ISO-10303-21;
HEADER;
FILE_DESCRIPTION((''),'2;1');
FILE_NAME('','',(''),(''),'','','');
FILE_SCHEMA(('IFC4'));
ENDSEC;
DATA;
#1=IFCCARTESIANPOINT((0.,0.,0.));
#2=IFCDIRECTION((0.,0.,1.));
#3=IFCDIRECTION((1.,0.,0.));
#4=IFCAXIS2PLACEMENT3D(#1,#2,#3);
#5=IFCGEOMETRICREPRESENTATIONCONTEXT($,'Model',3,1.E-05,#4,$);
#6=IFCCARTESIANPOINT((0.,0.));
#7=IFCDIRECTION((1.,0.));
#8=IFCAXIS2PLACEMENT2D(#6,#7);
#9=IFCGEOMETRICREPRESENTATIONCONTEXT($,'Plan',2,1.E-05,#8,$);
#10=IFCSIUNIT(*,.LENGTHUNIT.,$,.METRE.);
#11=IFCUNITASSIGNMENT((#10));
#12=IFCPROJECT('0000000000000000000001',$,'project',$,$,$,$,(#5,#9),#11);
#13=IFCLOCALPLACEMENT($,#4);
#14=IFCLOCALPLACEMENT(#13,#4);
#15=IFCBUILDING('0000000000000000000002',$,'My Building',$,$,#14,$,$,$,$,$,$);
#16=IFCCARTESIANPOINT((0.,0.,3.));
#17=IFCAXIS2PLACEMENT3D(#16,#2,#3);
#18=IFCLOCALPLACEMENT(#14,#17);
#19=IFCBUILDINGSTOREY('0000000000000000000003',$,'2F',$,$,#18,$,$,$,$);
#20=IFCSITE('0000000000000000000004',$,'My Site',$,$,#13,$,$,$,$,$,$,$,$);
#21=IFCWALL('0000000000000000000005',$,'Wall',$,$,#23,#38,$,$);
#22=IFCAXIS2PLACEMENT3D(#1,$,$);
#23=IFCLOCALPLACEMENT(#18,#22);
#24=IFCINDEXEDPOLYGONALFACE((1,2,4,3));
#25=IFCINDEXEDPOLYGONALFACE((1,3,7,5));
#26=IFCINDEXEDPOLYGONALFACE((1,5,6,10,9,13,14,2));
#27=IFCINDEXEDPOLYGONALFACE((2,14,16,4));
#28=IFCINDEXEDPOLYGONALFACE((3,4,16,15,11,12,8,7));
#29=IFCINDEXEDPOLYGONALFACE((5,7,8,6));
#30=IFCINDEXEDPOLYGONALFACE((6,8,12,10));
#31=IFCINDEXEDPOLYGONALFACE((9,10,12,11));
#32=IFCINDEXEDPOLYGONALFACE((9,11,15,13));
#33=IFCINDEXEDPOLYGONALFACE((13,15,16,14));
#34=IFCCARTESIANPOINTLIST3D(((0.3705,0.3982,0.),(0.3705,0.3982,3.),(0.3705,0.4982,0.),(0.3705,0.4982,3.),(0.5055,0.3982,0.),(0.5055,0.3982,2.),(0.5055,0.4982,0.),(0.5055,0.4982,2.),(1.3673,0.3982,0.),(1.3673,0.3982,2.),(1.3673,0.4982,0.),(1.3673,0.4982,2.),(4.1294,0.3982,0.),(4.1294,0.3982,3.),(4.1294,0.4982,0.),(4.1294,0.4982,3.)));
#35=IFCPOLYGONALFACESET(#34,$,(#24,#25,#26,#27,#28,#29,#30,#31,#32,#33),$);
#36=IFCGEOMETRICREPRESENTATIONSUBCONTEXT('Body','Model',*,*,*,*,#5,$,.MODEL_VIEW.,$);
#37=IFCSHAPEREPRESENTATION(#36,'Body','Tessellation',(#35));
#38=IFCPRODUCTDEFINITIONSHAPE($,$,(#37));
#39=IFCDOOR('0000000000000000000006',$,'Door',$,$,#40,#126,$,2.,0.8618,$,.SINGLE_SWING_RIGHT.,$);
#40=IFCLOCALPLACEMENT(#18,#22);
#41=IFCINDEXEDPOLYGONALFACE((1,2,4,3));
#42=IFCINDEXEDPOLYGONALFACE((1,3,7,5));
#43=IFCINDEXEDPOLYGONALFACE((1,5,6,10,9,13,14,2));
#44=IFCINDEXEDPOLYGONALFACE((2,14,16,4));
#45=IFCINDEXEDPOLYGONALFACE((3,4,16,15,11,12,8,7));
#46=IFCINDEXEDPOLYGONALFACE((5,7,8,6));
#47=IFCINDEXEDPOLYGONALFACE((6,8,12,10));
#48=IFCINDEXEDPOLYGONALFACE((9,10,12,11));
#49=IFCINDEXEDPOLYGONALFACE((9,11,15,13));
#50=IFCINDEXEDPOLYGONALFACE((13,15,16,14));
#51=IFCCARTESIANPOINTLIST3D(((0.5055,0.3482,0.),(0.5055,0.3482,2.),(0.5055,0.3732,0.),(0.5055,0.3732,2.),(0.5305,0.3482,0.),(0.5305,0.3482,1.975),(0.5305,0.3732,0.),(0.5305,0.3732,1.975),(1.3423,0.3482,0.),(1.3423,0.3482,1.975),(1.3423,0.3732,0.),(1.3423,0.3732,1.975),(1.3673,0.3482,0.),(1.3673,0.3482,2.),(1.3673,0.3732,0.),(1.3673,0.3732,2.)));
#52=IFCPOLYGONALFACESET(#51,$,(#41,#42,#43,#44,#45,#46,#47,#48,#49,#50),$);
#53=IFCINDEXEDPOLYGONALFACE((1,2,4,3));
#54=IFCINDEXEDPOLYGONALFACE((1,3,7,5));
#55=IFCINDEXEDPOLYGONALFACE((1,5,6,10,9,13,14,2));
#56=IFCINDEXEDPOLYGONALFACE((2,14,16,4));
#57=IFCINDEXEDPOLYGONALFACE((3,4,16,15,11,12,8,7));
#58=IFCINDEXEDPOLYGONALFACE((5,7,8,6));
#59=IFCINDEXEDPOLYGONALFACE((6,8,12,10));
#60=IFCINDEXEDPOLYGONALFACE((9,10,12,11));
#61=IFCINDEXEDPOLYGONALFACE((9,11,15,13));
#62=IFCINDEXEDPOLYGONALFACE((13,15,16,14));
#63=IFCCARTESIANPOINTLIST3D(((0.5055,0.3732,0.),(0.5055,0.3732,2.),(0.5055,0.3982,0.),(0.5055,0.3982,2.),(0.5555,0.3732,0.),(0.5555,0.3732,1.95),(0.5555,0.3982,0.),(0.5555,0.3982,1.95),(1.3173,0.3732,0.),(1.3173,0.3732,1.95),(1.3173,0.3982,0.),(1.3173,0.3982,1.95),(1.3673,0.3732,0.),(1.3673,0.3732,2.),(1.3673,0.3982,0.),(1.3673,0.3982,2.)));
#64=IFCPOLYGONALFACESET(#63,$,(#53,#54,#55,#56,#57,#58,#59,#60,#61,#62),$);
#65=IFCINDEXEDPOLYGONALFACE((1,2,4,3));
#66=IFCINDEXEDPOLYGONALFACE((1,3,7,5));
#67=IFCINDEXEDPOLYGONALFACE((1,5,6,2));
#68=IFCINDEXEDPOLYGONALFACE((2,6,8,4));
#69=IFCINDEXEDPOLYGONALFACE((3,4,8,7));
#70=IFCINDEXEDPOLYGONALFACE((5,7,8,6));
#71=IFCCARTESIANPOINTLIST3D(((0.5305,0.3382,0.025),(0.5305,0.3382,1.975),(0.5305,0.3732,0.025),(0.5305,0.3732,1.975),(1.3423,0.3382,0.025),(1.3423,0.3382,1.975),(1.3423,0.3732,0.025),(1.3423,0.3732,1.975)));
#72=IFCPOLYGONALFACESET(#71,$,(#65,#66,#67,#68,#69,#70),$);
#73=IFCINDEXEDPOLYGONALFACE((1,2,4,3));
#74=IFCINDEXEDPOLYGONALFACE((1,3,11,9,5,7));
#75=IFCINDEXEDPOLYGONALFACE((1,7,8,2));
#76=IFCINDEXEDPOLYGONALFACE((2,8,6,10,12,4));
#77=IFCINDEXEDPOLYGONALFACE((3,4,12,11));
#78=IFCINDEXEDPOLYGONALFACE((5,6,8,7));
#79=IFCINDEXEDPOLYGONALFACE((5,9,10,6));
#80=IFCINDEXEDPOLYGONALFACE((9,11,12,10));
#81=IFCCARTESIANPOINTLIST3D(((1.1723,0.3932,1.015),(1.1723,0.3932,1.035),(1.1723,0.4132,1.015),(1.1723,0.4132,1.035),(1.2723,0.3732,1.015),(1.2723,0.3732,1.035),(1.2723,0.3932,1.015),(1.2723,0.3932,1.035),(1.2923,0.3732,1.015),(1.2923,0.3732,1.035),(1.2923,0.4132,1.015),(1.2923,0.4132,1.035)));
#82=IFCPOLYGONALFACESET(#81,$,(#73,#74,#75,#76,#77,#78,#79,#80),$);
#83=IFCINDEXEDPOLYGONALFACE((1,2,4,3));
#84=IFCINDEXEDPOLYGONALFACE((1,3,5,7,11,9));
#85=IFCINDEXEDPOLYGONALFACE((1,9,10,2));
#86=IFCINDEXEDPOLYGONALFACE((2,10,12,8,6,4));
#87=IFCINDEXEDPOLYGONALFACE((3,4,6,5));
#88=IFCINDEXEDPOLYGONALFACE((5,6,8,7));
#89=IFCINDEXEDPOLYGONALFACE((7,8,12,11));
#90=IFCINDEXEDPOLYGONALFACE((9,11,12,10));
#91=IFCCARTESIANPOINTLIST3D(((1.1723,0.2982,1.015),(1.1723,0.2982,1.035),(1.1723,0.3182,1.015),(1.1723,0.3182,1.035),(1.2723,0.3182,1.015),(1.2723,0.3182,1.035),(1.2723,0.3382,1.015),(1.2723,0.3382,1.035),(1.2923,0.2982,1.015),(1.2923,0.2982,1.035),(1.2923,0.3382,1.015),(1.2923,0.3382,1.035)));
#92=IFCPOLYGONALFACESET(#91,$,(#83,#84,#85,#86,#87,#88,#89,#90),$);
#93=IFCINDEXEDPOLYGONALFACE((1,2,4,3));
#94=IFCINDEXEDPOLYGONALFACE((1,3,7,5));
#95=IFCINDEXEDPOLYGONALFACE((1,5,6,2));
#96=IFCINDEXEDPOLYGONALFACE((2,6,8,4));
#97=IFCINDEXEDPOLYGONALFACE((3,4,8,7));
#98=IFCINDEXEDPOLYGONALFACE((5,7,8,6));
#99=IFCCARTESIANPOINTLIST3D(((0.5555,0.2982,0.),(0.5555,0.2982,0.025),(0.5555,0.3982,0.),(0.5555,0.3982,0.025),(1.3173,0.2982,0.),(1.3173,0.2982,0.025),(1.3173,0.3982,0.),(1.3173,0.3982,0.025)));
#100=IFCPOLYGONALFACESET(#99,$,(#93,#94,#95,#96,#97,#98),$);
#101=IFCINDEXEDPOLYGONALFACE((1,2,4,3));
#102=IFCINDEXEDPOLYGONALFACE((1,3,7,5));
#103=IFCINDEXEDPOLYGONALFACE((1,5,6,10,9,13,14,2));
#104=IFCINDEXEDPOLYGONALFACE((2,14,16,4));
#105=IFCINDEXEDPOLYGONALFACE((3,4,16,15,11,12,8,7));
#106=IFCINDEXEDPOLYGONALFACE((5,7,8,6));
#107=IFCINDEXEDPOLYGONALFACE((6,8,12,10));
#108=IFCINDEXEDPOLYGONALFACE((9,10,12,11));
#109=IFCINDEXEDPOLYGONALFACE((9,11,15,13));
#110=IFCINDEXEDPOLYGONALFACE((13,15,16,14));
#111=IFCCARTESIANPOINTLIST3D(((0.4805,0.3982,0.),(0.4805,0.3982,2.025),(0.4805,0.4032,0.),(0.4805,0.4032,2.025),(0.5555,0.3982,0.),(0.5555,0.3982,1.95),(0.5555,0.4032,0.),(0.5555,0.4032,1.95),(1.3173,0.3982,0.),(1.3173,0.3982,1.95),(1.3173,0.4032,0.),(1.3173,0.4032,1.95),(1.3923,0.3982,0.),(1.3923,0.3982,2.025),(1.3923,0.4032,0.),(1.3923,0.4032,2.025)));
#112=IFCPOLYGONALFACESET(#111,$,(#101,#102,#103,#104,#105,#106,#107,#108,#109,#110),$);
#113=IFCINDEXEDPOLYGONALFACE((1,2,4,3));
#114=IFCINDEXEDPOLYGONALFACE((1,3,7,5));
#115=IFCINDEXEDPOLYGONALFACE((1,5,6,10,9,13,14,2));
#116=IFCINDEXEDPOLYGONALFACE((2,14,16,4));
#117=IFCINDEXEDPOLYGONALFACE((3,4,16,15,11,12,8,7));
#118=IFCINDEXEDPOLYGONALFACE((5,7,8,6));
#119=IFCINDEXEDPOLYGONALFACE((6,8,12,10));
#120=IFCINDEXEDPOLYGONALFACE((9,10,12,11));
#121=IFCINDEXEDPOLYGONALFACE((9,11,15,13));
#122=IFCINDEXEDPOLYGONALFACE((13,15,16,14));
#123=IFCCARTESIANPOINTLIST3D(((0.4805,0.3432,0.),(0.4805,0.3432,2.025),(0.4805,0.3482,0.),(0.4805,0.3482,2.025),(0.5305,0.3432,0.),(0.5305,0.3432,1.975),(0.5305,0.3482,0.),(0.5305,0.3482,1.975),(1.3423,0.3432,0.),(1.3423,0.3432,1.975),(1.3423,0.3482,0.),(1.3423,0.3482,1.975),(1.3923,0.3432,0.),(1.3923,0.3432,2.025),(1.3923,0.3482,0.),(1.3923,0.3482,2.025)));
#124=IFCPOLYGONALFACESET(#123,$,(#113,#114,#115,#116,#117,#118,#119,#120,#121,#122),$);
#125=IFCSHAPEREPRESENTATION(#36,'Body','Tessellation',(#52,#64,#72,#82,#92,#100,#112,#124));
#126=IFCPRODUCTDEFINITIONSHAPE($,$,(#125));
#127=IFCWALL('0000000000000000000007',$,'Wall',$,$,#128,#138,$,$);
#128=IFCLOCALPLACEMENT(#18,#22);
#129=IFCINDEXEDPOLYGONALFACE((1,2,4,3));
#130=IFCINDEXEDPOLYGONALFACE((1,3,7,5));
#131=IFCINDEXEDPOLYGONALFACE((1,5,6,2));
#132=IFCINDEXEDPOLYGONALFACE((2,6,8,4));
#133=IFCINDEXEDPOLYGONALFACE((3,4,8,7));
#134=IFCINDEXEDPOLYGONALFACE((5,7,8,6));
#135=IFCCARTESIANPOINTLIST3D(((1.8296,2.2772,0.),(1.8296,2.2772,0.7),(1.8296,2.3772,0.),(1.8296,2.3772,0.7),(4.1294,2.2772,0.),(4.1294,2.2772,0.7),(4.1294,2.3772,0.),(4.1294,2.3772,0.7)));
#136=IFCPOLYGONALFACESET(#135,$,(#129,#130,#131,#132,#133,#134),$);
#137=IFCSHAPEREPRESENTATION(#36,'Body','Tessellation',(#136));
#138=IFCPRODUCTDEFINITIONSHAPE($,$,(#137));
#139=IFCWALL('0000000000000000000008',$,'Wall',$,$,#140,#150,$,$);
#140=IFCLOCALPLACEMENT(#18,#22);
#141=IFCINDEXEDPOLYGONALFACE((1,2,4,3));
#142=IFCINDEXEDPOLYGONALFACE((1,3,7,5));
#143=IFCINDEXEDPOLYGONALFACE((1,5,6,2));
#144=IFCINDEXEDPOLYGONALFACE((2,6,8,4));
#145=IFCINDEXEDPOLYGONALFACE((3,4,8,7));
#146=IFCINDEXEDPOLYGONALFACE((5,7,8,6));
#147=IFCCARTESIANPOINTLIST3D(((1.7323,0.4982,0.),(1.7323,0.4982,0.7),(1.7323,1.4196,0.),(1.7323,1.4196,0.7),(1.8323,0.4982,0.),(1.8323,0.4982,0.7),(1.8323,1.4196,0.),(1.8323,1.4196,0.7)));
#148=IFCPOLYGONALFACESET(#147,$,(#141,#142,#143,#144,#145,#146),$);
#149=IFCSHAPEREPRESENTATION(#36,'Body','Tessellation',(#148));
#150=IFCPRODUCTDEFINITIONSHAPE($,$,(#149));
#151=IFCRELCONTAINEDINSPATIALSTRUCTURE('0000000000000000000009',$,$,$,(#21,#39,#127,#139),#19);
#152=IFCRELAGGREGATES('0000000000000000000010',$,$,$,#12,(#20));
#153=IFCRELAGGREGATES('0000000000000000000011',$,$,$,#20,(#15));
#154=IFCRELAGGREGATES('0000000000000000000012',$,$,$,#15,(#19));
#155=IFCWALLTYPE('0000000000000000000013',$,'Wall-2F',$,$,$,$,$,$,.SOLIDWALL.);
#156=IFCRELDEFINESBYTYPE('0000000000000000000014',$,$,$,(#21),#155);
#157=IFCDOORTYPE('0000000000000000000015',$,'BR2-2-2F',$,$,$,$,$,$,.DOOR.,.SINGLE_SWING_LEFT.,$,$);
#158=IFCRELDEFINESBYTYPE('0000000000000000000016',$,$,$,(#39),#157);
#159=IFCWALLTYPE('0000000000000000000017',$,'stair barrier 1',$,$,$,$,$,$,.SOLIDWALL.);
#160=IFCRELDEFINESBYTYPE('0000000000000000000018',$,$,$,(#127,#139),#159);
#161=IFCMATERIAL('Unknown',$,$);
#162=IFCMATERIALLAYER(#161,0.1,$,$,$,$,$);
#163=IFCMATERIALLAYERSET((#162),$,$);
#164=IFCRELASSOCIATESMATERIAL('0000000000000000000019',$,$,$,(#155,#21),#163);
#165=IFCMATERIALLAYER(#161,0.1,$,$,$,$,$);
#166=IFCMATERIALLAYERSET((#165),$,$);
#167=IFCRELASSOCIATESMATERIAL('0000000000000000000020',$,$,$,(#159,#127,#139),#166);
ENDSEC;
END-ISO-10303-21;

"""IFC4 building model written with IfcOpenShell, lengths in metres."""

from ifc_helpers import new_model, entity, si_unit, frame, origin_with_axes, origin_2d_with_axis, place, context, subcontext, project, spatial, line, indexed_curve, outline, extrude, shape, source, transform, mapped, material, layer, layer_set, layer_usage, type_object, type_shapes, element, fill, save


model = new_model("IFC4")

# Units and contexts
model_context = context("Model", 3, precision=1e-05, world=origin_with_axes())
plan_context = context("Plan", 2, precision=1e-05, world=origin_2d_with_axis())
body_context_1 = subcontext(model_context, "Body", "Model", "MODEL_VIEW")
body_context_2 = subcontext(plan_context, "Body", "Plan", "PLAN_VIEW")
ifc_project = project(units=[si_unit("LENGTHUNIT", "METRE")], contexts=[model_context, plan_context])

# Site, building, storey
site_placement = place(None, origin_with_axes())
site = spatial("IfcSite", under=ifc_project, at=site_placement, Name="My Site")
building_placement = place(site_placement, origin_with_axes())
building = spatial("IfcBuilding", under=site, at=building_placement, Name="My Building")
storey_placement = place(building_placement, frame((0.0, 0.0, 3.0), z_axis=(0.0, 0.0, 1.0), x_axis=(1.0, 0.0, 0.0)))
storey = spatial("IfcBuildingStorey", under=building, at=storey_placement, Name="2F")

# Shared definitions
ifc_material = material(Name="Unknown")
ifc_layer_1 = layer(ifc_material, 0.1)
ifc_layer_set_1 = layer_set([ifc_layer_1])
wall_type_1 = type_object("IfcWallType", Name="Wall-2F", PredefinedType="SOLIDWALL", material=ifc_layer_set_1)

# Wall, opening, door
ifc_layer_usage_1 = layer_usage(ifc_layer_set_1, "AXIS2", "NEGATIVE", 0.0)
wall_1_placement = place(storey_placement, frame((0.3705, 0.4982, 0.0), z_axis=(0.0, 0.0, 1.0), x_axis=(1.0, 0.0, 0.0)))
wall_1 = element("IfcWall", 1, at=wall_1_placement, inside=storey, type_object=wall_type_1, material=ifc_layer_usage_1, Name="Wall", context=body_context_1, shape_type="SweptSolid", body=[
    extrude(outline(indexed_curve([(0.0, -0.1), (0.0, 0.0), (3.7589, 0.0), (3.7589, -0.1)], segments=[line(1, 2, 3, 4, 1)])), origin_with_axes(), (0.0, 0.0, 1.0), 3.0),
])
shared_shape_1 = source(origin_with_axes(), body_context_1, "Body", "SweptSolid", [
    extrude(outline(indexed_curve([(0.0, 0.0), (0.8618, 0.0), (0.8618, 2.0), (0.0, 2.0)], segments=[line(1, 2, 3, 4, 1)])), frame((0.0, -0.6, 0.0), z_axis=(0.0, -1.0, 0.0), x_axis=(1.0, 0.0, 0.0)), (0.0, 0.0, -1.0), 1.2),
])
opening_1_placement = place(wall_1_placement, frame((0.9968, -0.1, 0.0), z_axis=(0.0, 0.0, 1.0), x_axis=(-1.0, 0.0, 0.0)))
opening_1 = element("IfcOpeningElement", 2, at=opening_1_placement, cuts=wall_1, PredefinedType="OPENING", context=body_context_1, shape_type="MappedRepresentation", body=[
    mapped(shared_shape_1, transform((0.0, 0.0, 0.0), x_axis=(1.0, 0.0, 0.0), y_axis=(0.0, 1.0, 0.0), z_axis=(0.0, 0.0, 1.0), scale=1.0)),
])
door_type_1 = type_object("IfcDoorType", Name="BR2-2-2F", OperationType="SINGLE_SWING_LEFT", PredefinedType="DOOR")
shared_shape_2 = source(origin_with_axes(), body_context_1, "Body", "SweptSolid", [
    extrude(outline(indexed_curve([(0.0, 0.0), (0.0, 2.0), (0.8618, 2.0), (0.8618, 0.0), (0.8368, 0.0), (0.8368, 1.975), (0.025, 1.975), (0.025, 0.0)], segments=[line(1, 2, 3, 4, 5, 6, 7, 8, 1)])), frame((0.0, 0.025, 0.0), z_axis=(0.0, -1.0, 0.0), x_axis=(1.0, 0.0, 0.0)), (0.0, 0.0, -1.0), 0.025),
    extrude(outline(indexed_curve([(0.0, 0.0), (0.0, 2.0), (0.8618, 2.0), (0.8618, 0.0), (0.8118, 0.0), (0.8118, 1.95), (0.05, 1.95), (0.05, 0.0)], segments=[line(1, 2, 3, 4, 5, 6, 7, 8, 1)])), frame((0.0, 0.0, 0.0), z_axis=(0.0, -1.0, 0.0), x_axis=(1.0, 0.0, 0.0)), (0.0, 0.0, -1.0), 0.025),
    extrude(outline(indexed_curve([(0.0, 0.0), (0.8118, 0.0), (0.8118, 0.035), (0.0, 0.035)], segments=[line(1, 2, 3, 4, 1)])), frame((0.025, 0.025, 0.025), z_axis=(0.0, 0.0, 1.0), x_axis=(1.0, 0.0, 0.0)), (0.0, 0.0, 1.0), 1.95),
    extrude(outline(indexed_curve([(0.0, 0.0), (0.0, -0.04), (0.12, -0.04), (0.12, -0.02), (0.02, -0.02), (0.02, 0.0)], segments=[line(1, 2, 3, 4, 5, 6, 1)])), frame((0.075, 0.025, 1.015), z_axis=(0.0, 0.0, 1.0), x_axis=(1.0, 0.0, 0.0)), (0.0, 0.0, 1.0), 0.02),
    extrude(outline(indexed_curve([(0.0, 0.0), (0.0, 0.04), (0.12, 0.04), (0.12, 0.02), (0.02, 0.02), (0.02, 0.0)], segments=[line(1, 2, 3, 4, 5, 6, 1)])), frame((0.075, 0.06, 1.015), z_axis=(0.0, 0.0, 1.0), x_axis=(1.0, 0.0, 0.0)), (0.0, 0.0, 1.0), 0.02),
    extrude(outline(indexed_curve([(0.0, 0.0), (0.7618, 0.0), (0.7618, 0.1), (0.0, 0.1)], segments=[line(1, 2, 3, 4, 1)])), frame((0.05, 0.0, 0.0), z_axis=(0.0, 0.0, 1.0), x_axis=(1.0, 0.0, 0.0)), (0.0, 0.0, 1.0), 0.025),
    extrude(outline(indexed_curve([(0.0, 0.0), (0.0, 2.025), (0.9118, 2.025), (0.9118, 0.0), (0.8368, 0.0), (0.8368, 1.95), (0.075, 1.95), (0.075, 0.0)], segments=[line(1, 2, 3, 4, 5, 6, 7, 8, 1)])), frame((-0.025, -0.005, 0.0), z_axis=(0.0, -1.0, 0.0), x_axis=(1.0, 0.0, 0.0)), (0.0, 0.0, -1.0), 0.005),
    extrude(outline(indexed_curve([(0.0, 0.0), (0.0, 2.025), (0.9118, 2.025), (0.9118, 0.0), (0.8618, 0.0), (0.8618, 1.975), (0.05, 1.975), (0.05, 0.0)], segments=[line(1, 2, 3, 4, 5, 6, 7, 8, 1)])), frame((-0.025, 0.05, 0.0), z_axis=(0.0, -1.0, 0.0), x_axis=(1.0, 0.0, 0.0)), (0.0, 0.0, -1.0), 0.005),
])
shared_shape_3 = source(origin_with_axes(), body_context_2, "Body", "Curve2D", [
    entity("IfcIndexedPolyCurve", entity("IfcCartesianPointList2D", [[0.0, 0.0], [0.0, 0.05], [0.025, 0.05], [0.025, 0.025], [0.05, 0.025], [0.05, 0.0]]), [entity("IfcLineIndex", [1, 2, 3, 4, 5, 6, 1])]),
    entity("IfcIndexedPolyCurve", entity("IfcCartesianPointList2D", [[0.8618, 0.0], [0.8618, 0.05], [0.8368, 0.05], [0.8368, 0.025], [0.8118, 0.025], [0.8118, 0.0]]), [entity("IfcLineIndex", [1, 2, 3, 4, 5, 6, 1])]),
    entity("IfcTrimmedCurve", entity("IfcEllipse", entity("IfcAxis2Placement2D", entity("IfcCartesianPoint", [0.8018, 0.05]), entity("IfcDirection", [1.0, 0.0])), 0.7768, 0.8118), [entity("IfcCartesianPoint", [0.8018, 0.8618])], [entity("IfcCartesianPoint", [0.025, 0.05])], True, "CARTESIAN"),
    entity("IfcIndexedPolyCurve", entity("IfcCartesianPointList2D", [[0.8368, 0.05], [0.8018, 0.05], [0.8018, 0.8618], [0.8368, 0.8618]]), [entity("IfcLineIndex", [1, 2, 3, 4, 1])]),
])
type_shapes(door_type_1, [shared_shape_2, shared_shape_3])
door_1_placement = place(opening_1_placement, frame((0.0, 0.0, 0.0), z_axis=(0.0, 0.0, 1.0), x_axis=(1.0, 0.0, 0.0)))
door_1 = element("IfcDoor", 3, at=door_1_placement, inside=storey, type_object=door_type_1, Name="Door", OperationType="SINGLE_SWING_RIGHT", OverallHeight=2.0, OverallWidth=0.8618, shapes=[
    shape(body_context_1, "Body", "MappedRepresentation", [mapped(shared_shape_2, transform((0.0, 0.0, 0.0), x_axis=(1.0, 0.0, 0.0), y_axis=(0.0, 1.0, 0.0), z_axis=(0.0, 0.0, 1.0), scale=1.0))]),
    shape(body_context_2, "Body", "MappedRepresentation", [mapped(shared_shape_3, transform((0.0, 0.0, 0.0), x_axis=(1.0, 0.0, 0.0), y_axis=(0.0, 1.0, 0.0), z_axis=(0.0, 0.0, 1.0), scale=1.0))]),
])
fill(opening_1, door_1)

# Walls
ifc_layer_2 = layer(ifc_material, 0.1)
ifc_layer_set_2 = layer_set([ifc_layer_2])
ifc_layer_usage_2 = layer_usage(ifc_layer_set_2, "AXIS2", "POSITIVE", 0.0)
wall_type_2 = type_object("IfcWallType", Name="stair barrier 1", PredefinedType="SOLIDWALL", material=ifc_layer_set_2)
wall_2_placement = place(storey_placement, frame((1.8296, 2.2772, 0.0), z_axis=(0.0, 0.0, 1.0), x_axis=(1.0, 0.0, 0.0)))
element("IfcWall", 4, at=wall_2_placement, inside=storey, type_object=wall_type_2, material=ifc_layer_usage_2, Name="Wall", context=body_context_1, shape_type="SweptSolid", body=[
    extrude(outline(indexed_curve([(0.0, 0.0), (0.0, 0.1), (2.2998, 0.1), (2.2998, 0.0)], segments=[line(1, 2, 3, 4, 1)])), origin_with_axes(), (0.0, 0.0, 1.0), 0.7),
])
ifc_layer_usage_3 = layer_usage(ifc_layer_set_2, "AXIS2", "POSITIVE", 0.0)
wall_3_placement = place(storey_placement, frame((1.7323, 1.4196, 0.0), z_axis=(0.0, 0.0, 1.0), x_axis=(0.0, -1.0, 0.0)))
element("IfcWall", 5, at=wall_3_placement, inside=storey, type_object=wall_type_2, material=ifc_layer_usage_3, Name="Wall", context=body_context_1, shape_type="SweptSolid", body=[
    extrude(outline(indexed_curve([(0.0, 0.0), (0.0, 0.1), (0.9214, 0.1), (0.9214, 0.0)], segments=[line(1, 2, 3, 4, 1)])), origin_with_axes(), (0.0, 0.0, 1.0), 0.7),
])

save(model, "model.ifc")
